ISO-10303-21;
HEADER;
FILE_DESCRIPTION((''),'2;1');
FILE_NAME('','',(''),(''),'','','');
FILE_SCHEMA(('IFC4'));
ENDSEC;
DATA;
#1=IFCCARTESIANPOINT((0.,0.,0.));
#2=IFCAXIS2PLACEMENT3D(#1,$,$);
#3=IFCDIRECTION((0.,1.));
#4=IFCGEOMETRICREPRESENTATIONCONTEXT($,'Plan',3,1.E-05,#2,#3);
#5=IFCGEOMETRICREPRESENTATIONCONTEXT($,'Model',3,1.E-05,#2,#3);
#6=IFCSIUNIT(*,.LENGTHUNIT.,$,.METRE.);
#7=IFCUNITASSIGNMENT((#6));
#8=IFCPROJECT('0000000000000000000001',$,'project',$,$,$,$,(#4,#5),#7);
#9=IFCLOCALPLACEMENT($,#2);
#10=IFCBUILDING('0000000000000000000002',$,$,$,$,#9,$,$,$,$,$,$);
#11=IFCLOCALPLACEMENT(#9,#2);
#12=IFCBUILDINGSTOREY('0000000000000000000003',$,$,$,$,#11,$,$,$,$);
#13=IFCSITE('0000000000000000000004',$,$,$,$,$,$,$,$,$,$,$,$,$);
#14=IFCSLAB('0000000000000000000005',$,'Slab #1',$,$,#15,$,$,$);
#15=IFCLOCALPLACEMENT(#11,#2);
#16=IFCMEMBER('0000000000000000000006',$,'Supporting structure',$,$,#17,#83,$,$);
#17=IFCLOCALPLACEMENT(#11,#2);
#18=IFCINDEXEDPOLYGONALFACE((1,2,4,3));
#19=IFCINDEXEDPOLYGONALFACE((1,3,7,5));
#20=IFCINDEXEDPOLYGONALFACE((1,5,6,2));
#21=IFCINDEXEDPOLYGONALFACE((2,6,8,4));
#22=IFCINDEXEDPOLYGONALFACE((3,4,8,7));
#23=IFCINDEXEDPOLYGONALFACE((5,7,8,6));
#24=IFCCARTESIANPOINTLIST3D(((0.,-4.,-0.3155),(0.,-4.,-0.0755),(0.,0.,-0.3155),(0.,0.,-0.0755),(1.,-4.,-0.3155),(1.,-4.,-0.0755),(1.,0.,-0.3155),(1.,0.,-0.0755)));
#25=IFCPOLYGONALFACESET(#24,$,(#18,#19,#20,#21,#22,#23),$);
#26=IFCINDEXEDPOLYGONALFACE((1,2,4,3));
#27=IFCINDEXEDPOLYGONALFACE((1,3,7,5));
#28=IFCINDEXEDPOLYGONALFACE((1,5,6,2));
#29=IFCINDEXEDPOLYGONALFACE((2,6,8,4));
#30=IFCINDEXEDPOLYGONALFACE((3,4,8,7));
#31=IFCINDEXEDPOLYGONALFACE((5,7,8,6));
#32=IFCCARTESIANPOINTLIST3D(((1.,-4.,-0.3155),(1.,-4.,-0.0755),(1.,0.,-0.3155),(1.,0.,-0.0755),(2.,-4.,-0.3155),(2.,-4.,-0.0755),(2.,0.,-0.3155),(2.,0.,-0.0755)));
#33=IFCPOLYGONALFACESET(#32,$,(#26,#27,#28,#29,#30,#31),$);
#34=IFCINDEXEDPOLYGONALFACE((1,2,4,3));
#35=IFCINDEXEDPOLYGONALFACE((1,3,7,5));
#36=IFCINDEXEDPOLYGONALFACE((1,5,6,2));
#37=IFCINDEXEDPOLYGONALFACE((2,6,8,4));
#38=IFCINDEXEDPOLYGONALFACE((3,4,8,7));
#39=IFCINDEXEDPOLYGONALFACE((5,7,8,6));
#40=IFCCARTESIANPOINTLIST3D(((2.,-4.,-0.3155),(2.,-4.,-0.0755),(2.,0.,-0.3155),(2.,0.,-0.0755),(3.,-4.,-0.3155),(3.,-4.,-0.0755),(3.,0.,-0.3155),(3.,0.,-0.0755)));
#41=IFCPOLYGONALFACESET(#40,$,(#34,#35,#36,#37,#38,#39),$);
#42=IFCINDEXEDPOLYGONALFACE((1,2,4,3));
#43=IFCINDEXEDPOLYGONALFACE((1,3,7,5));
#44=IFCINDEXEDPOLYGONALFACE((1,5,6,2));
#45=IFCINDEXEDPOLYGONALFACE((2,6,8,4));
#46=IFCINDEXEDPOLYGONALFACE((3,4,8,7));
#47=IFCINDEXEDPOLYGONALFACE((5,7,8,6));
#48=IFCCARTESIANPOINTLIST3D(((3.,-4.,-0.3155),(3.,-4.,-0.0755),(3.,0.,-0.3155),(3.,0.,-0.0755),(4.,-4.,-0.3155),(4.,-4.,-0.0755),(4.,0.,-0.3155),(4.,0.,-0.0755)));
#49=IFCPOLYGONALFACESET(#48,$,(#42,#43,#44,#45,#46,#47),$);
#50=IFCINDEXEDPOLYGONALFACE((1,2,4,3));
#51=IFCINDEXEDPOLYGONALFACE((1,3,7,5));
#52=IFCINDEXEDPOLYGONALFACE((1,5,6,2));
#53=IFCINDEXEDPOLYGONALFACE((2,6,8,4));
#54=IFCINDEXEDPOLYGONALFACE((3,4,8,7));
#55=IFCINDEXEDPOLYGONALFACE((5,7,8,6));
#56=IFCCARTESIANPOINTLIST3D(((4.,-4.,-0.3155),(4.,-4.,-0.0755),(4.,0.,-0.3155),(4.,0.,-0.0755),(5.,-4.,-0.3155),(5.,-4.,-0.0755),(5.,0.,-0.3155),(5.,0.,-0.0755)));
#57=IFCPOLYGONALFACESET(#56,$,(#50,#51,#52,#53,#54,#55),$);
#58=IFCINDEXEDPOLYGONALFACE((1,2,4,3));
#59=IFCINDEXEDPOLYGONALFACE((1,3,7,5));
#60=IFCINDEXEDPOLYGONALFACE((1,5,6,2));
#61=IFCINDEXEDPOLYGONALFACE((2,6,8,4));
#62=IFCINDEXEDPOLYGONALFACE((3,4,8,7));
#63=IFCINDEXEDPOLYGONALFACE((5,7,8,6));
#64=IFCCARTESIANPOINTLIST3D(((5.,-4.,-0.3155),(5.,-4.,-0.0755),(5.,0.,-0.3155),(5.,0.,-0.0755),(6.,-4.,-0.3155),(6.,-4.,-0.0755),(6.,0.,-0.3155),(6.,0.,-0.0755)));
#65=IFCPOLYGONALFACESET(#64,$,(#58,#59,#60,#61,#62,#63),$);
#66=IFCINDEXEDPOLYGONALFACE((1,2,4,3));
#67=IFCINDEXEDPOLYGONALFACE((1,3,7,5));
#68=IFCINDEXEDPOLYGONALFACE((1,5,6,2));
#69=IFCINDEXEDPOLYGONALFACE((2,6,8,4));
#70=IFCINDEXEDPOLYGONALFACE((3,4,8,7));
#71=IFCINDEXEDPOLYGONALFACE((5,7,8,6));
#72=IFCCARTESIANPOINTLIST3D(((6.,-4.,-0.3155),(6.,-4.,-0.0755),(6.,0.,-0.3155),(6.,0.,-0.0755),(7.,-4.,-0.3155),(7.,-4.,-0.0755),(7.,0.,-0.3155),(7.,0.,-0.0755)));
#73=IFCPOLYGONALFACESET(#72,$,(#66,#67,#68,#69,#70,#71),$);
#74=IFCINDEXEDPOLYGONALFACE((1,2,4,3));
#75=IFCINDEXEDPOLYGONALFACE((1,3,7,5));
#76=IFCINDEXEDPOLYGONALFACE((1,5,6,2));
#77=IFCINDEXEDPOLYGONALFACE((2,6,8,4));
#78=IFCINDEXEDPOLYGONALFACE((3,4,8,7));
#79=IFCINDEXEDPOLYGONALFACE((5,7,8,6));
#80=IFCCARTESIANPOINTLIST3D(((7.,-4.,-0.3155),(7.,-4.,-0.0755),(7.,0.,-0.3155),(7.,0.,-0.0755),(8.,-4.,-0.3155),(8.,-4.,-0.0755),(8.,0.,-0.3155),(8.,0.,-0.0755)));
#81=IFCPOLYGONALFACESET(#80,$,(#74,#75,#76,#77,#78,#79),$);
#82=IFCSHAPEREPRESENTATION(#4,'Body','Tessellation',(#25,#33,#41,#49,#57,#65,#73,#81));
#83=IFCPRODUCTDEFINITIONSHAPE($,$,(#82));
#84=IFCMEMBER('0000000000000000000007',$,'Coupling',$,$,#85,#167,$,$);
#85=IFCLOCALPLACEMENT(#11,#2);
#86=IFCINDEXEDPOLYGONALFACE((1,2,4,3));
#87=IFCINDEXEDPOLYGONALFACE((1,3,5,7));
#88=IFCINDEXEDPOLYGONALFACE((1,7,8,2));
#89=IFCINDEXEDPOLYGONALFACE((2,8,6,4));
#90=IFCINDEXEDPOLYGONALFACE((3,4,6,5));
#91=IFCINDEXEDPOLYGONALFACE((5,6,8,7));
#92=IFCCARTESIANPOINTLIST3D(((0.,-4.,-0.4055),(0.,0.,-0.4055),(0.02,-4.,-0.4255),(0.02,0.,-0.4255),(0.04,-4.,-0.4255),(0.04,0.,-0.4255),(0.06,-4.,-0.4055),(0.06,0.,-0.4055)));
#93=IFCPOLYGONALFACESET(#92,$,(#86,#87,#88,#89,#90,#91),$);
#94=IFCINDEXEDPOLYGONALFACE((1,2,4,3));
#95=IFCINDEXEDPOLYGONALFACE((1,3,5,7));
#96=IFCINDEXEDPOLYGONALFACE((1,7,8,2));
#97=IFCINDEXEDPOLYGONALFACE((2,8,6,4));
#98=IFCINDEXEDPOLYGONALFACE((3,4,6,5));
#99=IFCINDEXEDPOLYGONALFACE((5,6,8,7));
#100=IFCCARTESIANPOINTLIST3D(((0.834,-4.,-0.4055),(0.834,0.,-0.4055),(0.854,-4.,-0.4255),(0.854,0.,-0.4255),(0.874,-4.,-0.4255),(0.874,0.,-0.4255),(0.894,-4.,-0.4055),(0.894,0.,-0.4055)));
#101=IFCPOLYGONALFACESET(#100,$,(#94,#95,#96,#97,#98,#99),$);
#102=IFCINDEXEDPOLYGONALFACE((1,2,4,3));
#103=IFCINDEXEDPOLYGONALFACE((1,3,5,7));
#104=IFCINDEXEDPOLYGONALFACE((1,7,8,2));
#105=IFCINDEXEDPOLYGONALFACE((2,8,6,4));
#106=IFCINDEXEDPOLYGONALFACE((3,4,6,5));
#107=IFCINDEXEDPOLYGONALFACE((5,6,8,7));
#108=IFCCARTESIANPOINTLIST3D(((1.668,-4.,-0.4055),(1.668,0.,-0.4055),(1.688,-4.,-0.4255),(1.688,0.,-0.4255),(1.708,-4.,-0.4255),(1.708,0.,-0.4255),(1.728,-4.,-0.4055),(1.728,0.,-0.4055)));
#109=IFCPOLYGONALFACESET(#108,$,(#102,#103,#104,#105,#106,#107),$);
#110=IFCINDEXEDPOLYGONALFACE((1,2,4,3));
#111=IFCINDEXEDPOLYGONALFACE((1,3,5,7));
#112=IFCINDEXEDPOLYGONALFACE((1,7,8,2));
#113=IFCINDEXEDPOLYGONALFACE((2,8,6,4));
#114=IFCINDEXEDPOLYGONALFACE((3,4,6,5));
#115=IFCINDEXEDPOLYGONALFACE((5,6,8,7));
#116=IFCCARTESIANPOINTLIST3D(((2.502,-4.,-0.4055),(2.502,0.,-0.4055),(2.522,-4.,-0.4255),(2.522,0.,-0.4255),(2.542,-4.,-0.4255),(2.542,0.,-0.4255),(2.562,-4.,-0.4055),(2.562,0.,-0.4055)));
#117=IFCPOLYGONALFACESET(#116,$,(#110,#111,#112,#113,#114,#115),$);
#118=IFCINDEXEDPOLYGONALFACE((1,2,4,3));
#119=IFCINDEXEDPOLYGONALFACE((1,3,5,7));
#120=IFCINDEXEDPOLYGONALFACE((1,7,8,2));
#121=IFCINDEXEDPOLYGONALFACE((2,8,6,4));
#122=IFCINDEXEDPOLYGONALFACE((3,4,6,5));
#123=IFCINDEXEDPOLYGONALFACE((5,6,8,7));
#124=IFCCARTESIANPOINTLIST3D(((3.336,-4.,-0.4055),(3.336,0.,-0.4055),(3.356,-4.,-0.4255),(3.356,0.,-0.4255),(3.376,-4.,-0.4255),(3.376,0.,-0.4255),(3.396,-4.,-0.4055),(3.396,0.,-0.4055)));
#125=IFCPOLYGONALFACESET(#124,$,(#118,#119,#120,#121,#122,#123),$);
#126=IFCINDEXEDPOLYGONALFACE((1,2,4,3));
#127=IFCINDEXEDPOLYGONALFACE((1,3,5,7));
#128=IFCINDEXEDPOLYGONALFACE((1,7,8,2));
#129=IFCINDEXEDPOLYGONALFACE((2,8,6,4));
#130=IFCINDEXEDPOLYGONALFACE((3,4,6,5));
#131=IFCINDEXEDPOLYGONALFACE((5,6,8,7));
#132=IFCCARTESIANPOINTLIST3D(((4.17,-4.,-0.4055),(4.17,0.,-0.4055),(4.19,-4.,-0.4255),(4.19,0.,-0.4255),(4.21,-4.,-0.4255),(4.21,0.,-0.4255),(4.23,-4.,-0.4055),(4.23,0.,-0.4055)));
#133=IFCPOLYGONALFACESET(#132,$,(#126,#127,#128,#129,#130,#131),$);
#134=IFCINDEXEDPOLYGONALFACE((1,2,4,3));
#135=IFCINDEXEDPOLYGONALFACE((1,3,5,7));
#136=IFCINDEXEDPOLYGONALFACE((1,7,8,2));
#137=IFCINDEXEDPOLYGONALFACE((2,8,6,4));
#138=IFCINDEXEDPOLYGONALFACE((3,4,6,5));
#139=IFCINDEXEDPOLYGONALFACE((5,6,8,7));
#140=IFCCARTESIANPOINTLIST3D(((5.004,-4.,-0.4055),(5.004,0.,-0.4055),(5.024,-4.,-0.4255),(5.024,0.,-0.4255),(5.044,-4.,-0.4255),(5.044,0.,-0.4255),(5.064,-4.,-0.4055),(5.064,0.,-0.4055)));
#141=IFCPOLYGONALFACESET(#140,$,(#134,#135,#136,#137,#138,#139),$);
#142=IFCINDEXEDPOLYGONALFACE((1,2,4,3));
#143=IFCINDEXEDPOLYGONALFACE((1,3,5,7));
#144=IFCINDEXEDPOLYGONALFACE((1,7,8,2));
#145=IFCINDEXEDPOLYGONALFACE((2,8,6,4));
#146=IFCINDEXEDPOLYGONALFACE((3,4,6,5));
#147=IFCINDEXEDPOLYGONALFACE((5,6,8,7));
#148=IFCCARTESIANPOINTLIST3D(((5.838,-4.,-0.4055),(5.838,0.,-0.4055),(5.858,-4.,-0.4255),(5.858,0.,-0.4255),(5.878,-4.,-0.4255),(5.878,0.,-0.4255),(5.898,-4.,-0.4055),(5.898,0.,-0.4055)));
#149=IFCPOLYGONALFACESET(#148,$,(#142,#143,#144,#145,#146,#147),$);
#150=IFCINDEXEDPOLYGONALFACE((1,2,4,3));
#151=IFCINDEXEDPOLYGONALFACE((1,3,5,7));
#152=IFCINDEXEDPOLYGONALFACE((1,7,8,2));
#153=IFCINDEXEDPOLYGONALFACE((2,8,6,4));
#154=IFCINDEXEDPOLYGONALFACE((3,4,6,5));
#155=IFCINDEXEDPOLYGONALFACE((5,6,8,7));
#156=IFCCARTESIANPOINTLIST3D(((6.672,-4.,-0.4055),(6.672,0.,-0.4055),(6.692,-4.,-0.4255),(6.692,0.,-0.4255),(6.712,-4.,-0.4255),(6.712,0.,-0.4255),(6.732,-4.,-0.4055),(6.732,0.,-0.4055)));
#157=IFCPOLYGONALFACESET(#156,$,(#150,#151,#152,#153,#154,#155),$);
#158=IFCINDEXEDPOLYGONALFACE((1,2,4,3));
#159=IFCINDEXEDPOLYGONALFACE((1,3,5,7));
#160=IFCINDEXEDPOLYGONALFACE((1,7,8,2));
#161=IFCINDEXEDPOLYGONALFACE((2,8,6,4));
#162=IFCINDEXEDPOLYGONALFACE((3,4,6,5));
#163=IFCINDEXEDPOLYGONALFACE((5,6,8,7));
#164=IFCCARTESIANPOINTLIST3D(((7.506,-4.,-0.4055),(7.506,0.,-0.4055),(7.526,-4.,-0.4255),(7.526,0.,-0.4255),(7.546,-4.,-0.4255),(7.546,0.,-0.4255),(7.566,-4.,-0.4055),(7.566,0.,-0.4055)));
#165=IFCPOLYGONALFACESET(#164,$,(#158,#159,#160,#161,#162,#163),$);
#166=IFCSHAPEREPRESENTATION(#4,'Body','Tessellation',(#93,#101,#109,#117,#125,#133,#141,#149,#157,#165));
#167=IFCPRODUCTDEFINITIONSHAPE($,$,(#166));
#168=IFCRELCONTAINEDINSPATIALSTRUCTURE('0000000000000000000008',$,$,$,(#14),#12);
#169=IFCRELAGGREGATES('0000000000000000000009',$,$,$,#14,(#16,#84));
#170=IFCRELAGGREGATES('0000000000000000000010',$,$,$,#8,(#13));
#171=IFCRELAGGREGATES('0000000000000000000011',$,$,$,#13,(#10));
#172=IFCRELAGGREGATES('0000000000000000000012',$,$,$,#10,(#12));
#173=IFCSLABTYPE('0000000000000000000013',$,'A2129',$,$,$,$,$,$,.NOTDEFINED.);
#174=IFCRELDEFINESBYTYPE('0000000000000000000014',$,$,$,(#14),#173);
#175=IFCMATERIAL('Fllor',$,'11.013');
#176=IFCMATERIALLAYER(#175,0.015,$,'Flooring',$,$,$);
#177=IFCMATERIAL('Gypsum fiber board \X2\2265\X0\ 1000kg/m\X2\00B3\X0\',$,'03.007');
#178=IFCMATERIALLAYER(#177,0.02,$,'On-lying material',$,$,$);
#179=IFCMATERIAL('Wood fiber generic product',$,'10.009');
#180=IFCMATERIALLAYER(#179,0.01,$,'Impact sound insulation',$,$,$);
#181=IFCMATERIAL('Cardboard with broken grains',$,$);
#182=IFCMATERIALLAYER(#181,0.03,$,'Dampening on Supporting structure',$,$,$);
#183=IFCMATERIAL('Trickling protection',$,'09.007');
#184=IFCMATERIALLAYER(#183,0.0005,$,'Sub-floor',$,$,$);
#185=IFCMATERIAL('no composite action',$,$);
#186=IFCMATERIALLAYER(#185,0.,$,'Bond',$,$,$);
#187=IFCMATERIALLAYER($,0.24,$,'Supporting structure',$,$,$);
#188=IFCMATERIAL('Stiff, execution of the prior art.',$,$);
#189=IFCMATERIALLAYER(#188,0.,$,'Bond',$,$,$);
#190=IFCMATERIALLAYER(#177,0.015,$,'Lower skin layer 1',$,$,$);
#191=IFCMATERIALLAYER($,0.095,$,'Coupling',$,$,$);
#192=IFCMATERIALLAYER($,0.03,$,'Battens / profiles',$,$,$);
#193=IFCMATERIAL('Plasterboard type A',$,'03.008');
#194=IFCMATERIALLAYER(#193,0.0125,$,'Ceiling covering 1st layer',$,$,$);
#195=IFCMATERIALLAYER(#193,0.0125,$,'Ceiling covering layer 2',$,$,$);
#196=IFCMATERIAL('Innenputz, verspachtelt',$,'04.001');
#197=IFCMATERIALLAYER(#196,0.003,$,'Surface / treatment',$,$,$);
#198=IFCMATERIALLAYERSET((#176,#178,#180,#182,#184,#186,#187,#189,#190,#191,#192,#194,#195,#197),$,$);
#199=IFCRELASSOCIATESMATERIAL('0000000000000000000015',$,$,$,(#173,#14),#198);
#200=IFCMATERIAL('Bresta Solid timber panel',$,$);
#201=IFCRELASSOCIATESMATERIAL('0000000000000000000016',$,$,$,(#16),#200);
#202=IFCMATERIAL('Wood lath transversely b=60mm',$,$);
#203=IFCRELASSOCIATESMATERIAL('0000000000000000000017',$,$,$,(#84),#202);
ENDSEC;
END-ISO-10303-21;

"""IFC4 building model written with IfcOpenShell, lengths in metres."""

from ifc_helpers import new_model, si_unit, direction, frame, frame_2d, origin, place, context, project, spatial, polyline, rectangle, outline, extrude, material, layer, layer_set, type_object, element, aggregate, save


model = new_model("IFC4")

# Units and contexts
plan_context = context("Plan", 3, precision=1e-05, world=origin(), true_north=direction((0.0, 1.0)))
model_context = context("Model", 3, precision=1e-05, world=origin(), true_north=direction((0.0, 1.0)))
ifc_project = project(units=[si_unit("LENGTHUNIT", "METRE")], contexts=[plan_context, model_context])

# Site, building, storey
site = spatial("IfcSite", under=ifc_project)
building_placement = place(None, origin())
building = spatial("IfcBuilding", under=site, at=building_placement)
storey_placement = place(building_placement, origin())
storey = spatial("IfcBuildingStorey", under=building, at=storey_placement)

# Slab, members
ifc_material_1 = material(Name="Fllor", Category="11.013")
ifc_layer_1 = layer(ifc_material_1, 0.015, Name="Flooring")
ifc_material_2 = material(Name="Gypsum fiber board ≥ 1000kg/m³", Category="03.007")
ifc_layer_2 = layer(ifc_material_2, 0.02, Name="On-lying material")
ifc_material_3 = material(Name="Wood fiber generic product", Category="10.009")
ifc_layer_3 = layer(ifc_material_3, 0.01, Name="Impact sound insulation")
ifc_material_4 = material(Name="Cardboard with broken grains")
ifc_layer_4 = layer(ifc_material_4, 0.03, Name="Dampening on Supporting structure")
ifc_material_5 = material(Name="Trickling protection", Category="09.007")
ifc_layer_5 = layer(ifc_material_5, 0.0005, Name="Sub-floor")
ifc_material_6 = material(Name="no composite action")
ifc_layer_6 = layer(ifc_material_6, 0.0, Name="Bond")
ifc_layer_7 = layer(None, 0.24, Name="Supporting structure")
ifc_material_7 = material(Name="Stiff, execution of the prior art.")
ifc_layer_8 = layer(ifc_material_7, 0.0, Name="Bond")
ifc_layer_9 = layer(ifc_material_2, 0.015, Name="Lower skin layer 1")
ifc_layer_10 = layer(None, 0.095, Name="Coupling")
ifc_layer_11 = layer(None, 0.03, Name="Battens / profiles")
ifc_material_8 = material(Name="Plasterboard type A", Category="03.008")
ifc_layer_12 = layer(ifc_material_8, 0.0125, Name="Ceiling covering 1st layer")
ifc_layer_13 = layer(ifc_material_8, 0.0125, Name="Ceiling covering layer 2")
ifc_material_9 = material(Name="Innenputz, verspachtelt", Category="04.001")
ifc_layer_14 = layer(ifc_material_9, 0.003, Name="Surface / treatment")
ifc_layer_set = layer_set([ifc_layer_1, ifc_layer_2, ifc_layer_3, ifc_layer_4, ifc_layer_5, ifc_layer_6, ifc_layer_7, ifc_layer_8, ifc_layer_9, ifc_layer_10, ifc_layer_11, ifc_layer_12, ifc_layer_13, ifc_layer_14])
slab_type = type_object("IfcSlabType", Name="A2129", PredefinedType="NOTDEFINED", material=ifc_layer_set)
slab_placement = place(None, frame((0.0, 0.0, 0.0), z_axis=(0.0, 0.0, -1.0), x_axis=(1.0, 0.0, 0.0)))
slab = element("IfcSlab", 1, at=slab_placement, inside=storey, type_object=slab_type, material=ifc_layer_set, Name="Slab #1")
ifc_material_10 = material(Name="Bresta Solid timber panel")
member_1_placement = place(slab_placement, origin())
member_1 = element("IfcMember", 2, at=member_1_placement, material=ifc_material_10, Name="Supporting structure", context=plan_context, shape_type="SweptSolid", body=[
    extrude(rectangle(XDim=1.0, YDim=0.24, at=frame_2d((0.5, 0.12), x_axis=(1.0, 0.0))), frame((0.0, 4.0, 0.0755), z_axis=(0.0, -1.0, 0.0), x_axis=(1.0, 0.0, 0.0)), (0.0, 0.0, 1.0), 4.0),
    extrude(rectangle(XDim=1.0, YDim=0.24, at=frame_2d((0.5, 0.12), x_axis=(1.0, 0.0))), frame((1.0, 4.0, 0.0755), z_axis=(0.0, -1.0, 0.0), x_axis=(1.0, 0.0, 0.0)), (0.0, 0.0, 1.0), 4.0),
    extrude(rectangle(XDim=1.0, YDim=0.24, at=frame_2d((0.5, 0.12), x_axis=(1.0, 0.0))), frame((2.0, 4.0, 0.0755), z_axis=(0.0, -1.0, 0.0), x_axis=(1.0, 0.0, 0.0)), (0.0, 0.0, 1.0), 4.0),
    extrude(rectangle(XDim=1.0, YDim=0.24, at=frame_2d((0.5, 0.12), x_axis=(1.0, 0.0))), frame((3.0, 4.0, 0.0755), z_axis=(0.0, -1.0, 0.0), x_axis=(1.0, 0.0, 0.0)), (0.0, 0.0, 1.0), 4.0),
    extrude(rectangle(XDim=1.0, YDim=0.24, at=frame_2d((0.5, 0.12), x_axis=(1.0, 0.0))), frame((4.0, 4.0, 0.0755), z_axis=(0.0, -1.0, 0.0), x_axis=(1.0, 0.0, 0.0)), (0.0, 0.0, 1.0), 4.0),
    extrude(rectangle(XDim=1.0, YDim=0.24, at=frame_2d((0.5, 0.12), x_axis=(1.0, 0.0))), frame((5.0, 4.0, 0.0755), z_axis=(0.0, -1.0, 0.0), x_axis=(1.0, 0.0, 0.0)), (0.0, 0.0, 1.0), 4.0),
    extrude(rectangle(XDim=1.0, YDim=0.24, at=frame_2d((0.5, 0.12), x_axis=(1.0, 0.0))), frame((6.0, 4.0, 0.0755), z_axis=(0.0, -1.0, 0.0), x_axis=(1.0, 0.0, 0.0)), (0.0, 0.0, 1.0), 4.0),
    extrude(rectangle(XDim=1.0, YDim=0.24, at=frame_2d((0.5, 0.12), x_axis=(1.0, 0.0))), frame((7.0, 4.0, 0.0755), z_axis=(0.0, -1.0, 0.0), x_axis=(1.0, 0.0, 0.0)), (0.0, 0.0, 1.0), 4.0),
])
ifc_material_11 = material(Name="Wood lath transversely b=60mm")
member_2_placement = place(slab_placement, origin())
member_2 = element("IfcMember", 3, at=member_2_placement, material=ifc_material_11, Name="Coupling", context=plan_context, shape_type="SweptSolid", body=[
    extrude(outline(polyline([(0.0, 0.0), (0.06, 0.0), (0.04, 0.02), (0.02, 0.02), (0.0, 0.0)])), frame((0.0, 4.0, 0.4055), z_axis=(0.0, -1.0, 0.0), x_axis=(1.0, 0.0, 0.0)), (0.0, 0.0, 1.0), 4.0),
    extrude(outline(polyline([(0.0, 0.0), (0.06, 0.0), (0.04, 0.02), (0.02, 0.02), (0.0, 0.0)])), frame((0.834, 4.0, 0.4055), z_axis=(0.0, -1.0, 0.0), x_axis=(1.0, 0.0, 0.0)), (0.0, 0.0, 1.0), 4.0),
    extrude(outline(polyline([(0.0, 0.0), (0.06, 0.0), (0.04, 0.02), (0.02, 0.02), (0.0, 0.0)])), frame((1.668, 4.0, 0.4055), z_axis=(0.0, -1.0, 0.0), x_axis=(1.0, 0.0, 0.0)), (0.0, 0.0, 1.0), 4.0),
    extrude(outline(polyline([(0.0, 0.0), (0.06, 0.0), (0.04, 0.02), (0.02, 0.02), (0.0, 0.0)])), frame((2.502, 4.0, 0.4055), z_axis=(0.0, -1.0, 0.0), x_axis=(1.0, 0.0, 0.0)), (0.0, 0.0, 1.0), 4.0),
    extrude(outline(polyline([(0.0, 0.0), (0.06, 0.0), (0.04, 0.02), (0.02, 0.02), (0.0, 0.0)])), frame((3.336, 4.0, 0.4055), z_axis=(0.0, -1.0, 0.0), x_axis=(1.0, 0.0, 0.0)), (0.0, 0.0, 1.0), 4.0),
    extrude(outline(polyline([(0.0, 0.0), (0.06, 0.0), (0.04, 0.02), (0.02, 0.02), (0.0, 0.0)])), frame((4.17, 4.0, 0.4055), z_axis=(0.0, -1.0, 0.0), x_axis=(1.0, 0.0, 0.0)), (0.0, 0.0, 1.0), 4.0),
    extrude(outline(polyline([(0.0, 0.0), (0.06, 0.0), (0.04, 0.02), (0.02, 0.02), (0.0, 0.0)])), frame((5.004, 4.0, 0.4055), z_axis=(0.0, -1.0, 0.0), x_axis=(1.0, 0.0, 0.0)), (0.0, 0.0, 1.0), 4.0),
    extrude(outline(polyline([(0.0, 0.0), (0.06, 0.0), (0.04, 0.02), (0.02, 0.02), (0.0, 0.0)])), frame((5.838, 4.0, 0.4055), z_axis=(0.0, -1.0, 0.0), x_axis=(1.0, 0.0, 0.0)), (0.0, 0.0, 1.0), 4.0),
    extrude(outline(polyline([(0.0, 0.0), (0.06, 0.0), (0.04, 0.02), (0.02, 0.02), (0.0, 0.0)])), frame((6.672, 4.0, 0.4055), z_axis=(0.0, -1.0, 0.0), x_axis=(1.0, 0.0, 0.0)), (0.0, 0.0, 1.0), 4.0),
    extrude(outline(polyline([(0.0, 0.0), (0.06, 0.0), (0.04, 0.02), (0.02, 0.02), (0.0, 0.0)])), frame((7.506, 4.0, 0.4055), z_axis=(0.0, -1.0, 0.0), x_axis=(1.0, 0.0, 0.0)), (0.0, 0.0, 1.0), 4.0),
])
aggregate(slab, [member_1, member_2])

save(model, "model.ifc")
